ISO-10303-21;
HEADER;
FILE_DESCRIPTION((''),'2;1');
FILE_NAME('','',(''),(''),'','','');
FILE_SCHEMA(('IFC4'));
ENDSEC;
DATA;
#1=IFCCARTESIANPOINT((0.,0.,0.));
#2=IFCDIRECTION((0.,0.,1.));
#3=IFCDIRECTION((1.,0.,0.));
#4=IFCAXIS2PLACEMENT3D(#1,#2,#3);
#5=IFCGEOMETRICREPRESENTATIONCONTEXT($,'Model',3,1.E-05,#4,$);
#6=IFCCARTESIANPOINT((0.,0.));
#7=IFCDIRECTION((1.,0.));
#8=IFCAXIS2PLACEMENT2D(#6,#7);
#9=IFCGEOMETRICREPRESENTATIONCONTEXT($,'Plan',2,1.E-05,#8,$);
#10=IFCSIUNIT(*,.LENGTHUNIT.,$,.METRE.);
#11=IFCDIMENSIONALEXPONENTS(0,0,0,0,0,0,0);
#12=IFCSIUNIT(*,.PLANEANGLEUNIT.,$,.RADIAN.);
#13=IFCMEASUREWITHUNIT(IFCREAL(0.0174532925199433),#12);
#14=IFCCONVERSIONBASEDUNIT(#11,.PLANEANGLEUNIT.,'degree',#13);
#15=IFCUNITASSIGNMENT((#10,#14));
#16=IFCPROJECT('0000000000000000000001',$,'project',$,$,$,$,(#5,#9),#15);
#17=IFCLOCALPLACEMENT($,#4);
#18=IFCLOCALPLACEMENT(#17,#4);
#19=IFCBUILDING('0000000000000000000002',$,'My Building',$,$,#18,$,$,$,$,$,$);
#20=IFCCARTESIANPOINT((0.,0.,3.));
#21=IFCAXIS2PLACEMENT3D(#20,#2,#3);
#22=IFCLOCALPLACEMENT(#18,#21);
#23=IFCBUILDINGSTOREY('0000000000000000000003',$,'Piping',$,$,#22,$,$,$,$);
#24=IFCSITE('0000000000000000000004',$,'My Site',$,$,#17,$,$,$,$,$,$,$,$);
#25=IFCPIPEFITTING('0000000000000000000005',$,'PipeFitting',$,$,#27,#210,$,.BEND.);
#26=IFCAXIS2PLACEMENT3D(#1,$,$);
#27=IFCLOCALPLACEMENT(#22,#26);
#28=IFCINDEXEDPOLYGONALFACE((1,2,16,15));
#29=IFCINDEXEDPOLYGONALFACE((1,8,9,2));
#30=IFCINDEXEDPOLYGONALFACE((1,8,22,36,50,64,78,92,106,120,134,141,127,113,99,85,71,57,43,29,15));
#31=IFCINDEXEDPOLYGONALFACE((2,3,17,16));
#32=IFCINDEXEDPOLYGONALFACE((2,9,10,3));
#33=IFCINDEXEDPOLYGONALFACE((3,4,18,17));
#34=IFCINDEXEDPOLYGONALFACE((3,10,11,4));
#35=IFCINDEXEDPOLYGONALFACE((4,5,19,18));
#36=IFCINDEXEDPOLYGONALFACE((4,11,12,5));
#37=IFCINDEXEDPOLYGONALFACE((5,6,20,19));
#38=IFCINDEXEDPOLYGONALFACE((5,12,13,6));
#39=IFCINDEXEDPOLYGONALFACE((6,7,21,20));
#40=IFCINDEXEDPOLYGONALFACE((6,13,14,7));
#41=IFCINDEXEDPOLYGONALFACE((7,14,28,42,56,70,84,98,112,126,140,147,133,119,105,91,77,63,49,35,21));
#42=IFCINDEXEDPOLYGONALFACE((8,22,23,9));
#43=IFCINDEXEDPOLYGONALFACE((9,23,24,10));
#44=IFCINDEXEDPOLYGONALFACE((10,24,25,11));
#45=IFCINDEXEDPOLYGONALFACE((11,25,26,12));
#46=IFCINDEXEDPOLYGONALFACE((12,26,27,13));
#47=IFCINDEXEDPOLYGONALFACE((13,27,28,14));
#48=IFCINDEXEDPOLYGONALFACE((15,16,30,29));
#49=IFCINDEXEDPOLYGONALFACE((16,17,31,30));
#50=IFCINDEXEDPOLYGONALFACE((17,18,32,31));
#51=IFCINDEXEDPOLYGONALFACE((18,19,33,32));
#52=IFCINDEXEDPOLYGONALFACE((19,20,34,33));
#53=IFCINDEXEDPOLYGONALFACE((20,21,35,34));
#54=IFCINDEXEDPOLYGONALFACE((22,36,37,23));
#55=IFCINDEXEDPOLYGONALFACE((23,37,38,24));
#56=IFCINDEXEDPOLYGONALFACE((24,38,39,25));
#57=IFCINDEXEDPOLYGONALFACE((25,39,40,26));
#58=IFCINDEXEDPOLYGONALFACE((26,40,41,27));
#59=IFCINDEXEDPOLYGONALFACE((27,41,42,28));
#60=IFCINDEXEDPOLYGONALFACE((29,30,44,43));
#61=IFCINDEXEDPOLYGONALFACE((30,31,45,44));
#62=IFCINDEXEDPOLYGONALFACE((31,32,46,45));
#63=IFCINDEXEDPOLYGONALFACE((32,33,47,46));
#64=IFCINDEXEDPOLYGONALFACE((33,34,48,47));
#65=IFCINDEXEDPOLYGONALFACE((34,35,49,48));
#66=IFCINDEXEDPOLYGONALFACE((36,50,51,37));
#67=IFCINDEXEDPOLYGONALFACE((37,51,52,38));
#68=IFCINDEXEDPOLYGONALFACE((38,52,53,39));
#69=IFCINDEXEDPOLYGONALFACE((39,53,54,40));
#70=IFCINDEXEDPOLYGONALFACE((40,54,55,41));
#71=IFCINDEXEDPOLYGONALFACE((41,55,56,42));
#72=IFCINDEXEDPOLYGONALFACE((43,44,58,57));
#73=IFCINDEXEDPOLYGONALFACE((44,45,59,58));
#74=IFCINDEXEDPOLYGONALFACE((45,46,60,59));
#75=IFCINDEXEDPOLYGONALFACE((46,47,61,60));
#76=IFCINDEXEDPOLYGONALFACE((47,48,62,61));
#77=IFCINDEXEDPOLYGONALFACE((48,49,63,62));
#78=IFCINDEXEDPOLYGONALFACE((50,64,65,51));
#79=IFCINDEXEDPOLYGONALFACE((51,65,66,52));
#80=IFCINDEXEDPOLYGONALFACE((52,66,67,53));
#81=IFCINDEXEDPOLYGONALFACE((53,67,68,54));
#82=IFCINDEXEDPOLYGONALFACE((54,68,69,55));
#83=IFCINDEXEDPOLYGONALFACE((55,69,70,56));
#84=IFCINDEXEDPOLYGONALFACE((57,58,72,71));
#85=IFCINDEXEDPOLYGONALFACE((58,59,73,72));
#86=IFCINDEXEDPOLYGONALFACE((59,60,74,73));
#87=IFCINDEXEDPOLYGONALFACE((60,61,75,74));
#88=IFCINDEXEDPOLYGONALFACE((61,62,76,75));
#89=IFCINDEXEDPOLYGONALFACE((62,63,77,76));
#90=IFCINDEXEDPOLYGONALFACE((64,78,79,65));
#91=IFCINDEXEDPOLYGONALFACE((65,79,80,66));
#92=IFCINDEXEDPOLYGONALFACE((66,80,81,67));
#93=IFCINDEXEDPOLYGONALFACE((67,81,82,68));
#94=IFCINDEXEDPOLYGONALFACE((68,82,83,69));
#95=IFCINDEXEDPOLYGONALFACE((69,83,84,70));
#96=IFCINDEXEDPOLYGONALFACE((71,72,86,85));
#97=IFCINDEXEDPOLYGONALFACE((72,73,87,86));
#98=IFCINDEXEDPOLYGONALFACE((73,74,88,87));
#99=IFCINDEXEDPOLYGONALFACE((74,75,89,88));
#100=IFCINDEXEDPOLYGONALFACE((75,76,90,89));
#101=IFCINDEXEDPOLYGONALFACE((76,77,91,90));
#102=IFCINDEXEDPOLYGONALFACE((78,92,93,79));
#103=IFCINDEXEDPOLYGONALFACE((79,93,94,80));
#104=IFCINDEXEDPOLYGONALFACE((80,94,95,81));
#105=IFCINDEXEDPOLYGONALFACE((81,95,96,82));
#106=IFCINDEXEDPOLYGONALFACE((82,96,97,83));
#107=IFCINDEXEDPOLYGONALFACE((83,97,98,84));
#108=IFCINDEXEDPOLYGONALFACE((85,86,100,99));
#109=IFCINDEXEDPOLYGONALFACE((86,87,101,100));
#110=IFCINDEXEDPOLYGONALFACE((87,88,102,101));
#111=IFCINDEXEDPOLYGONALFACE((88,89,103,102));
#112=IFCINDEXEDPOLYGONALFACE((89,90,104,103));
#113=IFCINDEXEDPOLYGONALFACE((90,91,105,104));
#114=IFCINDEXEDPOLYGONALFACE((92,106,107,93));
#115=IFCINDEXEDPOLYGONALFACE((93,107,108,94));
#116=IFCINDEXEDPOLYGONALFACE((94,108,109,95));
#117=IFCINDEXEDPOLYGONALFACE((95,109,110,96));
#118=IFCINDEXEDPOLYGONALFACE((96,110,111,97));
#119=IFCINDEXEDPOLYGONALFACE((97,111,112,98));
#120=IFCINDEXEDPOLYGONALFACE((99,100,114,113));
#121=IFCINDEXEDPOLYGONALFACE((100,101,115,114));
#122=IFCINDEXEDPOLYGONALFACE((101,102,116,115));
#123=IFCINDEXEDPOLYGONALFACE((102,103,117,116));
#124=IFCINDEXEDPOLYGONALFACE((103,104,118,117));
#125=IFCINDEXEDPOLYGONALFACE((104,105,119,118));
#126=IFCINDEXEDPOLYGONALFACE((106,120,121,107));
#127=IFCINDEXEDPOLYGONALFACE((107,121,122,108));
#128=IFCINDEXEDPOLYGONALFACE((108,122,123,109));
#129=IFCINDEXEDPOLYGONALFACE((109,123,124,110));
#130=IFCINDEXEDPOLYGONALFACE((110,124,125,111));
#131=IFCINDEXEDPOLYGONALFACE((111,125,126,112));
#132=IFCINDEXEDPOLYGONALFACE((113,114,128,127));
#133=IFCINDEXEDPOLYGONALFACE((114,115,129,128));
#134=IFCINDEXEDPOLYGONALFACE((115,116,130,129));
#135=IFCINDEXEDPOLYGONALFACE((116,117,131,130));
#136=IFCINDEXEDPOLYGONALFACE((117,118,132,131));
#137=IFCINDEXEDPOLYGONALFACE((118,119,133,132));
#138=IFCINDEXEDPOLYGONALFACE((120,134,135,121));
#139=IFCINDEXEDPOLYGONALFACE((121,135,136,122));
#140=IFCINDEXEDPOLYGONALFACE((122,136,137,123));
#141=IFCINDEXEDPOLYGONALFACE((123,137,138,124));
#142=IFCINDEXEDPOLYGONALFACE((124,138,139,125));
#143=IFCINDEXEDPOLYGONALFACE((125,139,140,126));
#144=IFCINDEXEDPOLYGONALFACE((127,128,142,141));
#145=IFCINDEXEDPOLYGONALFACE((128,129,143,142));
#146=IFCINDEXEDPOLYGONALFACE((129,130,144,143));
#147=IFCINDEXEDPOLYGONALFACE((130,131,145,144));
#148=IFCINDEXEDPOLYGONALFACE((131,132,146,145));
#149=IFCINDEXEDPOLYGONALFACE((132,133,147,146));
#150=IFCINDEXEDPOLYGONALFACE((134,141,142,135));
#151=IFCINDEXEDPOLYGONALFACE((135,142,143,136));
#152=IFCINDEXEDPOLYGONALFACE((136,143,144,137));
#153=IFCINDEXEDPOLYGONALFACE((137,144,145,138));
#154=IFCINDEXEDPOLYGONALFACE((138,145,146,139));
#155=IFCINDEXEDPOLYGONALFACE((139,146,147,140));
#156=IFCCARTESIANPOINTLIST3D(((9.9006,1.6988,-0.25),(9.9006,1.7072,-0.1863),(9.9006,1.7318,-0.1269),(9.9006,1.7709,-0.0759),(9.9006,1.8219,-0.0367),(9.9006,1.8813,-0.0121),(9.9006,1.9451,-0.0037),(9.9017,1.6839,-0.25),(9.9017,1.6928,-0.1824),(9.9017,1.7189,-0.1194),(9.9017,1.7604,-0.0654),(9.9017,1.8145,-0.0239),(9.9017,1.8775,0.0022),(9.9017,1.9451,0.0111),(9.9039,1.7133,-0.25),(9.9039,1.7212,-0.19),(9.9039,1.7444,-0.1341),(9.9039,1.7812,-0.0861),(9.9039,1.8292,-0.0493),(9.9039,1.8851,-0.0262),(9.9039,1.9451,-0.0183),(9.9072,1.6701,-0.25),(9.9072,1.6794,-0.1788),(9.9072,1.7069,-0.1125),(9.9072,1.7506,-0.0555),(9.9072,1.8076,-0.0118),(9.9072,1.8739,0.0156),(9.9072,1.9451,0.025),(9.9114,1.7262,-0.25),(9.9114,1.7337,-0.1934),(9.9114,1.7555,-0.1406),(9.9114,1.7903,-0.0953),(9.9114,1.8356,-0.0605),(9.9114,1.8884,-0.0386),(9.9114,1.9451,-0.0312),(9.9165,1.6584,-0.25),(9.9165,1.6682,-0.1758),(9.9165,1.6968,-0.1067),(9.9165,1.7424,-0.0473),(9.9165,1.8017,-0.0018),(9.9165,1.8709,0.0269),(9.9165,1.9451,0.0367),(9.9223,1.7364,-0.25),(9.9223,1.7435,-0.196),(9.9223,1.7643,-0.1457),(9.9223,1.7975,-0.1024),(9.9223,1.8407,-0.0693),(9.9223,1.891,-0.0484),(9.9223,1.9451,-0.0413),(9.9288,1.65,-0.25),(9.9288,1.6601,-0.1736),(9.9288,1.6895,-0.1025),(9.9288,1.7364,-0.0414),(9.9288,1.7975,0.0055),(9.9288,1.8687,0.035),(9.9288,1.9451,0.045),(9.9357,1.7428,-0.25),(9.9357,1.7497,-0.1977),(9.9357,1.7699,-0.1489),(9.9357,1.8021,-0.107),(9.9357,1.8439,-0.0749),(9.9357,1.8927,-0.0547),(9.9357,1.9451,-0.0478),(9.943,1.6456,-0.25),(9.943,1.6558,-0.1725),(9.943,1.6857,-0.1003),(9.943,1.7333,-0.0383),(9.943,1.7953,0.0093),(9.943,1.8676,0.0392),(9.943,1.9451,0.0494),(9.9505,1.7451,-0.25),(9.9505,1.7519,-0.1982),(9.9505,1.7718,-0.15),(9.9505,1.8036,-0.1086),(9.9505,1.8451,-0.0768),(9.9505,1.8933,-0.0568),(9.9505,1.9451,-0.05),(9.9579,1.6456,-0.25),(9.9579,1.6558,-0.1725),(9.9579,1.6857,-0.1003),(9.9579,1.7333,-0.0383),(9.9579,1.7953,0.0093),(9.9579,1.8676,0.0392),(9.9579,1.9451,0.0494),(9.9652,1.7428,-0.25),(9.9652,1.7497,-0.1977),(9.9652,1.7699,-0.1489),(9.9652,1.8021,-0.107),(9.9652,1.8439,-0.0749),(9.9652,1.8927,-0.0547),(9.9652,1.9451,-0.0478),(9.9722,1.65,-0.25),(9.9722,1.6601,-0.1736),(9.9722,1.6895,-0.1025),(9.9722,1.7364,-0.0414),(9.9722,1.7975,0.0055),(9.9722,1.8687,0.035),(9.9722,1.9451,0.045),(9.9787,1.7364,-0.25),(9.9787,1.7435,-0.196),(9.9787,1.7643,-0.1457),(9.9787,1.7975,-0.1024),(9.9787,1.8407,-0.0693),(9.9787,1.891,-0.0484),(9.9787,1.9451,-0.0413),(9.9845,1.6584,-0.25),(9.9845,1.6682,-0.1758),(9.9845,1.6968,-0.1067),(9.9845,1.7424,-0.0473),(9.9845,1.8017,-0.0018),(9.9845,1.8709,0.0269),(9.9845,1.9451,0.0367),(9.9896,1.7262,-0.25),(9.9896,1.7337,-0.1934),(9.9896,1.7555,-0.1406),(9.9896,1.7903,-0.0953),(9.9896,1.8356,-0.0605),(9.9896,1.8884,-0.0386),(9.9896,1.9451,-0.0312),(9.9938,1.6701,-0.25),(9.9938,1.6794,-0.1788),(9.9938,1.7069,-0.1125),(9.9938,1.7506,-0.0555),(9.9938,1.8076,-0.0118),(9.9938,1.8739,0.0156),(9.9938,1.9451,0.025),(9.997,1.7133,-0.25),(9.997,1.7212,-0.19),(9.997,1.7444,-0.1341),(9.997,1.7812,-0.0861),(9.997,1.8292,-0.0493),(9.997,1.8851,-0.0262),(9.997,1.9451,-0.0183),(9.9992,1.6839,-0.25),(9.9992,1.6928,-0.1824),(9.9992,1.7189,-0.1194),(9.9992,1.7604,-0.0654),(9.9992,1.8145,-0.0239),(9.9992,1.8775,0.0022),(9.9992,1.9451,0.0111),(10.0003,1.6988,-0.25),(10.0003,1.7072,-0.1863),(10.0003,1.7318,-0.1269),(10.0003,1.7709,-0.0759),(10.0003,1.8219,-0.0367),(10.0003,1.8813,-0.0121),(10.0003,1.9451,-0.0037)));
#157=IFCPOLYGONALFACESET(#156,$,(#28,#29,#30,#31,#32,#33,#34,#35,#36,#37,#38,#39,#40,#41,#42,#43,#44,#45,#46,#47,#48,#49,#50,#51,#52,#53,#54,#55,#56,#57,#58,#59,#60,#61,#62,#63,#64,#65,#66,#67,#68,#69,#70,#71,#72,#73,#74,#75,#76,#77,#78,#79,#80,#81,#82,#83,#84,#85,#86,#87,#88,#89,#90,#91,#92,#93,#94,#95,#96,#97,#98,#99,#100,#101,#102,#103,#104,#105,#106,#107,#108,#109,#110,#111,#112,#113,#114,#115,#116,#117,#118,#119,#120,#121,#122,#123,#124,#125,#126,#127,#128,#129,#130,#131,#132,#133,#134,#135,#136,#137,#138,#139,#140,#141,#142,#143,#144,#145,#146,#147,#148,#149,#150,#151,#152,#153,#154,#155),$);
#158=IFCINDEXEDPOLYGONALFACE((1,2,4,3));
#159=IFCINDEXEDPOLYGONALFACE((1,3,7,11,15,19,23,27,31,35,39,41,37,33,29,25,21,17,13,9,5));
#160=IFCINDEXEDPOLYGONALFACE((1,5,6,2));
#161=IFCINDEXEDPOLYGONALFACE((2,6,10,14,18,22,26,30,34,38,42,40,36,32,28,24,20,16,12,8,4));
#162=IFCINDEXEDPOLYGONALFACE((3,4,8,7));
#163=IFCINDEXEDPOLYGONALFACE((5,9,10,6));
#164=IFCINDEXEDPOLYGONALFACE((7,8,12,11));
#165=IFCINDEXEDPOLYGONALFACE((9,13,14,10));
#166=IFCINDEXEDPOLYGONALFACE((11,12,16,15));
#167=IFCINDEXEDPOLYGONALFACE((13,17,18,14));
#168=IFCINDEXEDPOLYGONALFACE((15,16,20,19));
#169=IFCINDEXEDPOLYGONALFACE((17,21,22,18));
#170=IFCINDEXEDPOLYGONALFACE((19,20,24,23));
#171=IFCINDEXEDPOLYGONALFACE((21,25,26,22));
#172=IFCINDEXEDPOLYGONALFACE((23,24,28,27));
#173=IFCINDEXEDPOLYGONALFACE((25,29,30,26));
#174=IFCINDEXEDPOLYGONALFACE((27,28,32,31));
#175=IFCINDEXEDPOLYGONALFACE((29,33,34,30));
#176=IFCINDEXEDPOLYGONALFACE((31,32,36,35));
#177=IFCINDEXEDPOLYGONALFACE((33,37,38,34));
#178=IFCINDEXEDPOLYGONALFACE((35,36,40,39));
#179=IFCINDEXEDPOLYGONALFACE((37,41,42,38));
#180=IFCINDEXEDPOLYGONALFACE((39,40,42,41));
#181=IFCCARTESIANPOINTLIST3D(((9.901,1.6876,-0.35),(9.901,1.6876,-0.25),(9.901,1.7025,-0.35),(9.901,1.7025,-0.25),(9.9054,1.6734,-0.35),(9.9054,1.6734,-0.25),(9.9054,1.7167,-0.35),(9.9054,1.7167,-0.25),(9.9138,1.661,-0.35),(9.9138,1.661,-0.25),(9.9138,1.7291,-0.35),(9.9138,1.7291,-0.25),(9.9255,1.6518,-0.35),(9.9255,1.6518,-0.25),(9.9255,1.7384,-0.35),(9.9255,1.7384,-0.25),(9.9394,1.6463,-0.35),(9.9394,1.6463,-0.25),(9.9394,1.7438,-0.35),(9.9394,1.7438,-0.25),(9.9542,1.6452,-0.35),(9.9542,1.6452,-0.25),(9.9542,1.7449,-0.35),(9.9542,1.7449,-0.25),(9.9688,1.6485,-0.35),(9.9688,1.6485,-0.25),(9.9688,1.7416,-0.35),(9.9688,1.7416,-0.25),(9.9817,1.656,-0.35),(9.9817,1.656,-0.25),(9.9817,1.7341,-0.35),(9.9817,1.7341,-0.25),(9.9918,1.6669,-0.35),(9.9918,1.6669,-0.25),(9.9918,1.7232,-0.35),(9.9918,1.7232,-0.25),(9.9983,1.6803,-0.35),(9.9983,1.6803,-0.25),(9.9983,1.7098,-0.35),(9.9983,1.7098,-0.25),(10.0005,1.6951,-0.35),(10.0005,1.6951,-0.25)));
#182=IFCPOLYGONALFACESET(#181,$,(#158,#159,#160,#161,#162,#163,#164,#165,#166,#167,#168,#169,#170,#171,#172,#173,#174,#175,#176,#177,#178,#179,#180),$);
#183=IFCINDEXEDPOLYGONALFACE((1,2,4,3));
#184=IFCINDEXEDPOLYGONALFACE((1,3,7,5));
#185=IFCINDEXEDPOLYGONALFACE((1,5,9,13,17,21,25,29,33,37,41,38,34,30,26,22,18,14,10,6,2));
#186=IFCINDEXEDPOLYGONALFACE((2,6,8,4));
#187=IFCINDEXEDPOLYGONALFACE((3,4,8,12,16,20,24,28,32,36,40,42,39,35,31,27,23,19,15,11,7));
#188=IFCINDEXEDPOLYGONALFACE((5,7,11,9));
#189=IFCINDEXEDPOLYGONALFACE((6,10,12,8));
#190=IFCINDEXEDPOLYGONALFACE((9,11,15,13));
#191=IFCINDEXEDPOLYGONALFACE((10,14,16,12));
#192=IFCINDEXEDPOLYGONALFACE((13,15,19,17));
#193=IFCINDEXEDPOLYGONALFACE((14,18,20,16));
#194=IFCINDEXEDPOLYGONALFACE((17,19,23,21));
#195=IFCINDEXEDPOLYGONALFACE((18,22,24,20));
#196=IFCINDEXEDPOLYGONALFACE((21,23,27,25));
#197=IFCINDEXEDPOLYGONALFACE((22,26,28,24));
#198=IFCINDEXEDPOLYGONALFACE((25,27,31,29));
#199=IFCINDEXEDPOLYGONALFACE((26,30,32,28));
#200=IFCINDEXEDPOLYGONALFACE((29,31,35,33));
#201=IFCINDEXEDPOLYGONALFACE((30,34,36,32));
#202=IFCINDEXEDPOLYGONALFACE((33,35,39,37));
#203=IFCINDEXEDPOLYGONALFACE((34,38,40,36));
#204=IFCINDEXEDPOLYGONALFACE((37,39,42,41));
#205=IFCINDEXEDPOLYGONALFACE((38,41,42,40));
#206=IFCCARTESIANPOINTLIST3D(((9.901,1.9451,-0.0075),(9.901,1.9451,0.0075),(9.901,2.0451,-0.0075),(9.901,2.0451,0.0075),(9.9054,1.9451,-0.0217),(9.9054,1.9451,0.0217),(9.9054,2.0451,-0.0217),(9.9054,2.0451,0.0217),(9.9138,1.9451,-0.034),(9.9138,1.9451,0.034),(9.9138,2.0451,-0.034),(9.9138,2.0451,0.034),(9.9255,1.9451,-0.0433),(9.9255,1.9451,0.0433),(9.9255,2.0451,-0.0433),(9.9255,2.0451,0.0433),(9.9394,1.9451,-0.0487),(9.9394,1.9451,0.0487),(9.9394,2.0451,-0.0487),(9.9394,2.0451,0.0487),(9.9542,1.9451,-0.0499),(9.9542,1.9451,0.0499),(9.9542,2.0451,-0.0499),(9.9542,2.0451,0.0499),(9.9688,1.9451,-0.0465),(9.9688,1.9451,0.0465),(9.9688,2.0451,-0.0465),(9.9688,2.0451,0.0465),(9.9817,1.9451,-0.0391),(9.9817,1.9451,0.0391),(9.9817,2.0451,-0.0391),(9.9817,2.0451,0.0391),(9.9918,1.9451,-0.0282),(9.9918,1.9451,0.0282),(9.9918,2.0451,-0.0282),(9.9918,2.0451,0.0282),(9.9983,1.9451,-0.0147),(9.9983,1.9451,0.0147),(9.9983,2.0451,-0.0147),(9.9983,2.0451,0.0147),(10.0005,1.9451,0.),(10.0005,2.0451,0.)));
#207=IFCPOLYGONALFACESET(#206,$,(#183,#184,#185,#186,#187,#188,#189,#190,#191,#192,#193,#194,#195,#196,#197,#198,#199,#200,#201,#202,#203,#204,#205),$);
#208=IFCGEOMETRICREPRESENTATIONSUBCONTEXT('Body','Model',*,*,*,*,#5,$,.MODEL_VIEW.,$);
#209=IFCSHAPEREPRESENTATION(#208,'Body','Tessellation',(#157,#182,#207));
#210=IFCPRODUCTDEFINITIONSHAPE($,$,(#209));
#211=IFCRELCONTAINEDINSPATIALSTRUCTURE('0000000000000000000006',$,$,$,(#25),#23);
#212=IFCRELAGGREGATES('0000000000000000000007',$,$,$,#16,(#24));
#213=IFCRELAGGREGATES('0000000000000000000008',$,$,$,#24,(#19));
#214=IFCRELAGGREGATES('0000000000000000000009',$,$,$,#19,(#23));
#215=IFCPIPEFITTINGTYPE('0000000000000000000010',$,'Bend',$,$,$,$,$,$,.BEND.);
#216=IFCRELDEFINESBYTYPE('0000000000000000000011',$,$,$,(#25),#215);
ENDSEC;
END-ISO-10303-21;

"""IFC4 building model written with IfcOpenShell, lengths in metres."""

from ifc_helpers import new_model, entity, si_unit, converted_unit, frame, origin_with_axes, origin_2d_with_axis, place, context, subcontext, project, spatial, circle, extrude, source, transform, mapped, type_object, type_shapes, element, save


model = new_model("IFC4")

# Units and contexts
model_context = context("Model", 3, precision=1e-05, world=origin_with_axes())
plan_context = context("Plan", 2, precision=1e-05, world=origin_2d_with_axis())
body_context = subcontext(model_context, "Body", "Model", "MODEL_VIEW")
ifc_project = project(units=[si_unit("LENGTHUNIT", "METRE"), converted_unit("PLANEANGLEUNIT", "degree", entity("IfcReal", 0.0174532925199433), si_unit("PLANEANGLEUNIT", "RADIAN"), dimensions=[0, 0, 0, 0, 0, 0, 0])], contexts=[model_context, plan_context])

# Site, building, storey
site_placement = place(None, origin_with_axes())
site = spatial("IfcSite", under=ifc_project, at=site_placement, Name="My Site")
building_placement = place(site_placement, origin_with_axes())
building = spatial("IfcBuilding", under=site, at=building_placement, Name="My Building")
storey_placement = place(building_placement, frame((0.0, 0.0, 3.0), z_axis=(0.0, 0.0, 1.0), x_axis=(1.0, 0.0, 0.0)))
storey = spatial("IfcBuildingStorey", under=building, at=storey_placement, Name="Piping")

# Pipe fitting
pipe_fitting_type = type_object("IfcPipeFittingType", Name="Bend", PredefinedType="BEND")
shared_shape = source(origin_with_axes(), body_context, "Body", "SolidModel", [
    entity("IfcSweptDiskSolid", entity("IfcIndexedPolyCurve", entity("IfcCartesianPointList3D", [[0.0, 0.0, -0.1], [0.0, -0.0732, -0.2768], [0.0, -0.25, -0.35]]), [entity("IfcArcIndex", [1, 2, 3])]), 0.05),
    extrude(circle(Radius=0.05), origin_with_axes(), (0.0, 0.0, -1.0), 0.1),
    extrude(circle(Radius=0.05), frame((0.0, -0.25, -0.35), z_axis=(0.0, -1.0, 0.0), x_axis=(1.0, 0.0, 0.0)), (0.0, 0.0, 1.0), 0.1),
])
type_shapes(pipe_fitting_type, [shared_shape])
for number, where, z_axis, x_axis, name in (
    (1, (9.9505, 1.6951, -0.35), (0.0, 0.0, -1.0), (1.0, 0.0, 0.0), "PipeFitting"),
):
    element("IfcPipeFitting", number, at=place(storey_placement, frame(where, z_axis=z_axis, x_axis=x_axis)), inside=storey, type_object=pipe_fitting_type, Name=name, PredefinedType="BEND", context=body_context, shape_type="MappedRepresentation", body=[
        mapped(shared_shape, transform((0.0, 0.0, 0.0), x_axis=(1.0, 0.0, 0.0), y_axis=(0.0, 1.0, 0.0), z_axis=(0.0, 0.0, 1.0), scale=1.0)),
    ])

save(model, "model.ifc")
